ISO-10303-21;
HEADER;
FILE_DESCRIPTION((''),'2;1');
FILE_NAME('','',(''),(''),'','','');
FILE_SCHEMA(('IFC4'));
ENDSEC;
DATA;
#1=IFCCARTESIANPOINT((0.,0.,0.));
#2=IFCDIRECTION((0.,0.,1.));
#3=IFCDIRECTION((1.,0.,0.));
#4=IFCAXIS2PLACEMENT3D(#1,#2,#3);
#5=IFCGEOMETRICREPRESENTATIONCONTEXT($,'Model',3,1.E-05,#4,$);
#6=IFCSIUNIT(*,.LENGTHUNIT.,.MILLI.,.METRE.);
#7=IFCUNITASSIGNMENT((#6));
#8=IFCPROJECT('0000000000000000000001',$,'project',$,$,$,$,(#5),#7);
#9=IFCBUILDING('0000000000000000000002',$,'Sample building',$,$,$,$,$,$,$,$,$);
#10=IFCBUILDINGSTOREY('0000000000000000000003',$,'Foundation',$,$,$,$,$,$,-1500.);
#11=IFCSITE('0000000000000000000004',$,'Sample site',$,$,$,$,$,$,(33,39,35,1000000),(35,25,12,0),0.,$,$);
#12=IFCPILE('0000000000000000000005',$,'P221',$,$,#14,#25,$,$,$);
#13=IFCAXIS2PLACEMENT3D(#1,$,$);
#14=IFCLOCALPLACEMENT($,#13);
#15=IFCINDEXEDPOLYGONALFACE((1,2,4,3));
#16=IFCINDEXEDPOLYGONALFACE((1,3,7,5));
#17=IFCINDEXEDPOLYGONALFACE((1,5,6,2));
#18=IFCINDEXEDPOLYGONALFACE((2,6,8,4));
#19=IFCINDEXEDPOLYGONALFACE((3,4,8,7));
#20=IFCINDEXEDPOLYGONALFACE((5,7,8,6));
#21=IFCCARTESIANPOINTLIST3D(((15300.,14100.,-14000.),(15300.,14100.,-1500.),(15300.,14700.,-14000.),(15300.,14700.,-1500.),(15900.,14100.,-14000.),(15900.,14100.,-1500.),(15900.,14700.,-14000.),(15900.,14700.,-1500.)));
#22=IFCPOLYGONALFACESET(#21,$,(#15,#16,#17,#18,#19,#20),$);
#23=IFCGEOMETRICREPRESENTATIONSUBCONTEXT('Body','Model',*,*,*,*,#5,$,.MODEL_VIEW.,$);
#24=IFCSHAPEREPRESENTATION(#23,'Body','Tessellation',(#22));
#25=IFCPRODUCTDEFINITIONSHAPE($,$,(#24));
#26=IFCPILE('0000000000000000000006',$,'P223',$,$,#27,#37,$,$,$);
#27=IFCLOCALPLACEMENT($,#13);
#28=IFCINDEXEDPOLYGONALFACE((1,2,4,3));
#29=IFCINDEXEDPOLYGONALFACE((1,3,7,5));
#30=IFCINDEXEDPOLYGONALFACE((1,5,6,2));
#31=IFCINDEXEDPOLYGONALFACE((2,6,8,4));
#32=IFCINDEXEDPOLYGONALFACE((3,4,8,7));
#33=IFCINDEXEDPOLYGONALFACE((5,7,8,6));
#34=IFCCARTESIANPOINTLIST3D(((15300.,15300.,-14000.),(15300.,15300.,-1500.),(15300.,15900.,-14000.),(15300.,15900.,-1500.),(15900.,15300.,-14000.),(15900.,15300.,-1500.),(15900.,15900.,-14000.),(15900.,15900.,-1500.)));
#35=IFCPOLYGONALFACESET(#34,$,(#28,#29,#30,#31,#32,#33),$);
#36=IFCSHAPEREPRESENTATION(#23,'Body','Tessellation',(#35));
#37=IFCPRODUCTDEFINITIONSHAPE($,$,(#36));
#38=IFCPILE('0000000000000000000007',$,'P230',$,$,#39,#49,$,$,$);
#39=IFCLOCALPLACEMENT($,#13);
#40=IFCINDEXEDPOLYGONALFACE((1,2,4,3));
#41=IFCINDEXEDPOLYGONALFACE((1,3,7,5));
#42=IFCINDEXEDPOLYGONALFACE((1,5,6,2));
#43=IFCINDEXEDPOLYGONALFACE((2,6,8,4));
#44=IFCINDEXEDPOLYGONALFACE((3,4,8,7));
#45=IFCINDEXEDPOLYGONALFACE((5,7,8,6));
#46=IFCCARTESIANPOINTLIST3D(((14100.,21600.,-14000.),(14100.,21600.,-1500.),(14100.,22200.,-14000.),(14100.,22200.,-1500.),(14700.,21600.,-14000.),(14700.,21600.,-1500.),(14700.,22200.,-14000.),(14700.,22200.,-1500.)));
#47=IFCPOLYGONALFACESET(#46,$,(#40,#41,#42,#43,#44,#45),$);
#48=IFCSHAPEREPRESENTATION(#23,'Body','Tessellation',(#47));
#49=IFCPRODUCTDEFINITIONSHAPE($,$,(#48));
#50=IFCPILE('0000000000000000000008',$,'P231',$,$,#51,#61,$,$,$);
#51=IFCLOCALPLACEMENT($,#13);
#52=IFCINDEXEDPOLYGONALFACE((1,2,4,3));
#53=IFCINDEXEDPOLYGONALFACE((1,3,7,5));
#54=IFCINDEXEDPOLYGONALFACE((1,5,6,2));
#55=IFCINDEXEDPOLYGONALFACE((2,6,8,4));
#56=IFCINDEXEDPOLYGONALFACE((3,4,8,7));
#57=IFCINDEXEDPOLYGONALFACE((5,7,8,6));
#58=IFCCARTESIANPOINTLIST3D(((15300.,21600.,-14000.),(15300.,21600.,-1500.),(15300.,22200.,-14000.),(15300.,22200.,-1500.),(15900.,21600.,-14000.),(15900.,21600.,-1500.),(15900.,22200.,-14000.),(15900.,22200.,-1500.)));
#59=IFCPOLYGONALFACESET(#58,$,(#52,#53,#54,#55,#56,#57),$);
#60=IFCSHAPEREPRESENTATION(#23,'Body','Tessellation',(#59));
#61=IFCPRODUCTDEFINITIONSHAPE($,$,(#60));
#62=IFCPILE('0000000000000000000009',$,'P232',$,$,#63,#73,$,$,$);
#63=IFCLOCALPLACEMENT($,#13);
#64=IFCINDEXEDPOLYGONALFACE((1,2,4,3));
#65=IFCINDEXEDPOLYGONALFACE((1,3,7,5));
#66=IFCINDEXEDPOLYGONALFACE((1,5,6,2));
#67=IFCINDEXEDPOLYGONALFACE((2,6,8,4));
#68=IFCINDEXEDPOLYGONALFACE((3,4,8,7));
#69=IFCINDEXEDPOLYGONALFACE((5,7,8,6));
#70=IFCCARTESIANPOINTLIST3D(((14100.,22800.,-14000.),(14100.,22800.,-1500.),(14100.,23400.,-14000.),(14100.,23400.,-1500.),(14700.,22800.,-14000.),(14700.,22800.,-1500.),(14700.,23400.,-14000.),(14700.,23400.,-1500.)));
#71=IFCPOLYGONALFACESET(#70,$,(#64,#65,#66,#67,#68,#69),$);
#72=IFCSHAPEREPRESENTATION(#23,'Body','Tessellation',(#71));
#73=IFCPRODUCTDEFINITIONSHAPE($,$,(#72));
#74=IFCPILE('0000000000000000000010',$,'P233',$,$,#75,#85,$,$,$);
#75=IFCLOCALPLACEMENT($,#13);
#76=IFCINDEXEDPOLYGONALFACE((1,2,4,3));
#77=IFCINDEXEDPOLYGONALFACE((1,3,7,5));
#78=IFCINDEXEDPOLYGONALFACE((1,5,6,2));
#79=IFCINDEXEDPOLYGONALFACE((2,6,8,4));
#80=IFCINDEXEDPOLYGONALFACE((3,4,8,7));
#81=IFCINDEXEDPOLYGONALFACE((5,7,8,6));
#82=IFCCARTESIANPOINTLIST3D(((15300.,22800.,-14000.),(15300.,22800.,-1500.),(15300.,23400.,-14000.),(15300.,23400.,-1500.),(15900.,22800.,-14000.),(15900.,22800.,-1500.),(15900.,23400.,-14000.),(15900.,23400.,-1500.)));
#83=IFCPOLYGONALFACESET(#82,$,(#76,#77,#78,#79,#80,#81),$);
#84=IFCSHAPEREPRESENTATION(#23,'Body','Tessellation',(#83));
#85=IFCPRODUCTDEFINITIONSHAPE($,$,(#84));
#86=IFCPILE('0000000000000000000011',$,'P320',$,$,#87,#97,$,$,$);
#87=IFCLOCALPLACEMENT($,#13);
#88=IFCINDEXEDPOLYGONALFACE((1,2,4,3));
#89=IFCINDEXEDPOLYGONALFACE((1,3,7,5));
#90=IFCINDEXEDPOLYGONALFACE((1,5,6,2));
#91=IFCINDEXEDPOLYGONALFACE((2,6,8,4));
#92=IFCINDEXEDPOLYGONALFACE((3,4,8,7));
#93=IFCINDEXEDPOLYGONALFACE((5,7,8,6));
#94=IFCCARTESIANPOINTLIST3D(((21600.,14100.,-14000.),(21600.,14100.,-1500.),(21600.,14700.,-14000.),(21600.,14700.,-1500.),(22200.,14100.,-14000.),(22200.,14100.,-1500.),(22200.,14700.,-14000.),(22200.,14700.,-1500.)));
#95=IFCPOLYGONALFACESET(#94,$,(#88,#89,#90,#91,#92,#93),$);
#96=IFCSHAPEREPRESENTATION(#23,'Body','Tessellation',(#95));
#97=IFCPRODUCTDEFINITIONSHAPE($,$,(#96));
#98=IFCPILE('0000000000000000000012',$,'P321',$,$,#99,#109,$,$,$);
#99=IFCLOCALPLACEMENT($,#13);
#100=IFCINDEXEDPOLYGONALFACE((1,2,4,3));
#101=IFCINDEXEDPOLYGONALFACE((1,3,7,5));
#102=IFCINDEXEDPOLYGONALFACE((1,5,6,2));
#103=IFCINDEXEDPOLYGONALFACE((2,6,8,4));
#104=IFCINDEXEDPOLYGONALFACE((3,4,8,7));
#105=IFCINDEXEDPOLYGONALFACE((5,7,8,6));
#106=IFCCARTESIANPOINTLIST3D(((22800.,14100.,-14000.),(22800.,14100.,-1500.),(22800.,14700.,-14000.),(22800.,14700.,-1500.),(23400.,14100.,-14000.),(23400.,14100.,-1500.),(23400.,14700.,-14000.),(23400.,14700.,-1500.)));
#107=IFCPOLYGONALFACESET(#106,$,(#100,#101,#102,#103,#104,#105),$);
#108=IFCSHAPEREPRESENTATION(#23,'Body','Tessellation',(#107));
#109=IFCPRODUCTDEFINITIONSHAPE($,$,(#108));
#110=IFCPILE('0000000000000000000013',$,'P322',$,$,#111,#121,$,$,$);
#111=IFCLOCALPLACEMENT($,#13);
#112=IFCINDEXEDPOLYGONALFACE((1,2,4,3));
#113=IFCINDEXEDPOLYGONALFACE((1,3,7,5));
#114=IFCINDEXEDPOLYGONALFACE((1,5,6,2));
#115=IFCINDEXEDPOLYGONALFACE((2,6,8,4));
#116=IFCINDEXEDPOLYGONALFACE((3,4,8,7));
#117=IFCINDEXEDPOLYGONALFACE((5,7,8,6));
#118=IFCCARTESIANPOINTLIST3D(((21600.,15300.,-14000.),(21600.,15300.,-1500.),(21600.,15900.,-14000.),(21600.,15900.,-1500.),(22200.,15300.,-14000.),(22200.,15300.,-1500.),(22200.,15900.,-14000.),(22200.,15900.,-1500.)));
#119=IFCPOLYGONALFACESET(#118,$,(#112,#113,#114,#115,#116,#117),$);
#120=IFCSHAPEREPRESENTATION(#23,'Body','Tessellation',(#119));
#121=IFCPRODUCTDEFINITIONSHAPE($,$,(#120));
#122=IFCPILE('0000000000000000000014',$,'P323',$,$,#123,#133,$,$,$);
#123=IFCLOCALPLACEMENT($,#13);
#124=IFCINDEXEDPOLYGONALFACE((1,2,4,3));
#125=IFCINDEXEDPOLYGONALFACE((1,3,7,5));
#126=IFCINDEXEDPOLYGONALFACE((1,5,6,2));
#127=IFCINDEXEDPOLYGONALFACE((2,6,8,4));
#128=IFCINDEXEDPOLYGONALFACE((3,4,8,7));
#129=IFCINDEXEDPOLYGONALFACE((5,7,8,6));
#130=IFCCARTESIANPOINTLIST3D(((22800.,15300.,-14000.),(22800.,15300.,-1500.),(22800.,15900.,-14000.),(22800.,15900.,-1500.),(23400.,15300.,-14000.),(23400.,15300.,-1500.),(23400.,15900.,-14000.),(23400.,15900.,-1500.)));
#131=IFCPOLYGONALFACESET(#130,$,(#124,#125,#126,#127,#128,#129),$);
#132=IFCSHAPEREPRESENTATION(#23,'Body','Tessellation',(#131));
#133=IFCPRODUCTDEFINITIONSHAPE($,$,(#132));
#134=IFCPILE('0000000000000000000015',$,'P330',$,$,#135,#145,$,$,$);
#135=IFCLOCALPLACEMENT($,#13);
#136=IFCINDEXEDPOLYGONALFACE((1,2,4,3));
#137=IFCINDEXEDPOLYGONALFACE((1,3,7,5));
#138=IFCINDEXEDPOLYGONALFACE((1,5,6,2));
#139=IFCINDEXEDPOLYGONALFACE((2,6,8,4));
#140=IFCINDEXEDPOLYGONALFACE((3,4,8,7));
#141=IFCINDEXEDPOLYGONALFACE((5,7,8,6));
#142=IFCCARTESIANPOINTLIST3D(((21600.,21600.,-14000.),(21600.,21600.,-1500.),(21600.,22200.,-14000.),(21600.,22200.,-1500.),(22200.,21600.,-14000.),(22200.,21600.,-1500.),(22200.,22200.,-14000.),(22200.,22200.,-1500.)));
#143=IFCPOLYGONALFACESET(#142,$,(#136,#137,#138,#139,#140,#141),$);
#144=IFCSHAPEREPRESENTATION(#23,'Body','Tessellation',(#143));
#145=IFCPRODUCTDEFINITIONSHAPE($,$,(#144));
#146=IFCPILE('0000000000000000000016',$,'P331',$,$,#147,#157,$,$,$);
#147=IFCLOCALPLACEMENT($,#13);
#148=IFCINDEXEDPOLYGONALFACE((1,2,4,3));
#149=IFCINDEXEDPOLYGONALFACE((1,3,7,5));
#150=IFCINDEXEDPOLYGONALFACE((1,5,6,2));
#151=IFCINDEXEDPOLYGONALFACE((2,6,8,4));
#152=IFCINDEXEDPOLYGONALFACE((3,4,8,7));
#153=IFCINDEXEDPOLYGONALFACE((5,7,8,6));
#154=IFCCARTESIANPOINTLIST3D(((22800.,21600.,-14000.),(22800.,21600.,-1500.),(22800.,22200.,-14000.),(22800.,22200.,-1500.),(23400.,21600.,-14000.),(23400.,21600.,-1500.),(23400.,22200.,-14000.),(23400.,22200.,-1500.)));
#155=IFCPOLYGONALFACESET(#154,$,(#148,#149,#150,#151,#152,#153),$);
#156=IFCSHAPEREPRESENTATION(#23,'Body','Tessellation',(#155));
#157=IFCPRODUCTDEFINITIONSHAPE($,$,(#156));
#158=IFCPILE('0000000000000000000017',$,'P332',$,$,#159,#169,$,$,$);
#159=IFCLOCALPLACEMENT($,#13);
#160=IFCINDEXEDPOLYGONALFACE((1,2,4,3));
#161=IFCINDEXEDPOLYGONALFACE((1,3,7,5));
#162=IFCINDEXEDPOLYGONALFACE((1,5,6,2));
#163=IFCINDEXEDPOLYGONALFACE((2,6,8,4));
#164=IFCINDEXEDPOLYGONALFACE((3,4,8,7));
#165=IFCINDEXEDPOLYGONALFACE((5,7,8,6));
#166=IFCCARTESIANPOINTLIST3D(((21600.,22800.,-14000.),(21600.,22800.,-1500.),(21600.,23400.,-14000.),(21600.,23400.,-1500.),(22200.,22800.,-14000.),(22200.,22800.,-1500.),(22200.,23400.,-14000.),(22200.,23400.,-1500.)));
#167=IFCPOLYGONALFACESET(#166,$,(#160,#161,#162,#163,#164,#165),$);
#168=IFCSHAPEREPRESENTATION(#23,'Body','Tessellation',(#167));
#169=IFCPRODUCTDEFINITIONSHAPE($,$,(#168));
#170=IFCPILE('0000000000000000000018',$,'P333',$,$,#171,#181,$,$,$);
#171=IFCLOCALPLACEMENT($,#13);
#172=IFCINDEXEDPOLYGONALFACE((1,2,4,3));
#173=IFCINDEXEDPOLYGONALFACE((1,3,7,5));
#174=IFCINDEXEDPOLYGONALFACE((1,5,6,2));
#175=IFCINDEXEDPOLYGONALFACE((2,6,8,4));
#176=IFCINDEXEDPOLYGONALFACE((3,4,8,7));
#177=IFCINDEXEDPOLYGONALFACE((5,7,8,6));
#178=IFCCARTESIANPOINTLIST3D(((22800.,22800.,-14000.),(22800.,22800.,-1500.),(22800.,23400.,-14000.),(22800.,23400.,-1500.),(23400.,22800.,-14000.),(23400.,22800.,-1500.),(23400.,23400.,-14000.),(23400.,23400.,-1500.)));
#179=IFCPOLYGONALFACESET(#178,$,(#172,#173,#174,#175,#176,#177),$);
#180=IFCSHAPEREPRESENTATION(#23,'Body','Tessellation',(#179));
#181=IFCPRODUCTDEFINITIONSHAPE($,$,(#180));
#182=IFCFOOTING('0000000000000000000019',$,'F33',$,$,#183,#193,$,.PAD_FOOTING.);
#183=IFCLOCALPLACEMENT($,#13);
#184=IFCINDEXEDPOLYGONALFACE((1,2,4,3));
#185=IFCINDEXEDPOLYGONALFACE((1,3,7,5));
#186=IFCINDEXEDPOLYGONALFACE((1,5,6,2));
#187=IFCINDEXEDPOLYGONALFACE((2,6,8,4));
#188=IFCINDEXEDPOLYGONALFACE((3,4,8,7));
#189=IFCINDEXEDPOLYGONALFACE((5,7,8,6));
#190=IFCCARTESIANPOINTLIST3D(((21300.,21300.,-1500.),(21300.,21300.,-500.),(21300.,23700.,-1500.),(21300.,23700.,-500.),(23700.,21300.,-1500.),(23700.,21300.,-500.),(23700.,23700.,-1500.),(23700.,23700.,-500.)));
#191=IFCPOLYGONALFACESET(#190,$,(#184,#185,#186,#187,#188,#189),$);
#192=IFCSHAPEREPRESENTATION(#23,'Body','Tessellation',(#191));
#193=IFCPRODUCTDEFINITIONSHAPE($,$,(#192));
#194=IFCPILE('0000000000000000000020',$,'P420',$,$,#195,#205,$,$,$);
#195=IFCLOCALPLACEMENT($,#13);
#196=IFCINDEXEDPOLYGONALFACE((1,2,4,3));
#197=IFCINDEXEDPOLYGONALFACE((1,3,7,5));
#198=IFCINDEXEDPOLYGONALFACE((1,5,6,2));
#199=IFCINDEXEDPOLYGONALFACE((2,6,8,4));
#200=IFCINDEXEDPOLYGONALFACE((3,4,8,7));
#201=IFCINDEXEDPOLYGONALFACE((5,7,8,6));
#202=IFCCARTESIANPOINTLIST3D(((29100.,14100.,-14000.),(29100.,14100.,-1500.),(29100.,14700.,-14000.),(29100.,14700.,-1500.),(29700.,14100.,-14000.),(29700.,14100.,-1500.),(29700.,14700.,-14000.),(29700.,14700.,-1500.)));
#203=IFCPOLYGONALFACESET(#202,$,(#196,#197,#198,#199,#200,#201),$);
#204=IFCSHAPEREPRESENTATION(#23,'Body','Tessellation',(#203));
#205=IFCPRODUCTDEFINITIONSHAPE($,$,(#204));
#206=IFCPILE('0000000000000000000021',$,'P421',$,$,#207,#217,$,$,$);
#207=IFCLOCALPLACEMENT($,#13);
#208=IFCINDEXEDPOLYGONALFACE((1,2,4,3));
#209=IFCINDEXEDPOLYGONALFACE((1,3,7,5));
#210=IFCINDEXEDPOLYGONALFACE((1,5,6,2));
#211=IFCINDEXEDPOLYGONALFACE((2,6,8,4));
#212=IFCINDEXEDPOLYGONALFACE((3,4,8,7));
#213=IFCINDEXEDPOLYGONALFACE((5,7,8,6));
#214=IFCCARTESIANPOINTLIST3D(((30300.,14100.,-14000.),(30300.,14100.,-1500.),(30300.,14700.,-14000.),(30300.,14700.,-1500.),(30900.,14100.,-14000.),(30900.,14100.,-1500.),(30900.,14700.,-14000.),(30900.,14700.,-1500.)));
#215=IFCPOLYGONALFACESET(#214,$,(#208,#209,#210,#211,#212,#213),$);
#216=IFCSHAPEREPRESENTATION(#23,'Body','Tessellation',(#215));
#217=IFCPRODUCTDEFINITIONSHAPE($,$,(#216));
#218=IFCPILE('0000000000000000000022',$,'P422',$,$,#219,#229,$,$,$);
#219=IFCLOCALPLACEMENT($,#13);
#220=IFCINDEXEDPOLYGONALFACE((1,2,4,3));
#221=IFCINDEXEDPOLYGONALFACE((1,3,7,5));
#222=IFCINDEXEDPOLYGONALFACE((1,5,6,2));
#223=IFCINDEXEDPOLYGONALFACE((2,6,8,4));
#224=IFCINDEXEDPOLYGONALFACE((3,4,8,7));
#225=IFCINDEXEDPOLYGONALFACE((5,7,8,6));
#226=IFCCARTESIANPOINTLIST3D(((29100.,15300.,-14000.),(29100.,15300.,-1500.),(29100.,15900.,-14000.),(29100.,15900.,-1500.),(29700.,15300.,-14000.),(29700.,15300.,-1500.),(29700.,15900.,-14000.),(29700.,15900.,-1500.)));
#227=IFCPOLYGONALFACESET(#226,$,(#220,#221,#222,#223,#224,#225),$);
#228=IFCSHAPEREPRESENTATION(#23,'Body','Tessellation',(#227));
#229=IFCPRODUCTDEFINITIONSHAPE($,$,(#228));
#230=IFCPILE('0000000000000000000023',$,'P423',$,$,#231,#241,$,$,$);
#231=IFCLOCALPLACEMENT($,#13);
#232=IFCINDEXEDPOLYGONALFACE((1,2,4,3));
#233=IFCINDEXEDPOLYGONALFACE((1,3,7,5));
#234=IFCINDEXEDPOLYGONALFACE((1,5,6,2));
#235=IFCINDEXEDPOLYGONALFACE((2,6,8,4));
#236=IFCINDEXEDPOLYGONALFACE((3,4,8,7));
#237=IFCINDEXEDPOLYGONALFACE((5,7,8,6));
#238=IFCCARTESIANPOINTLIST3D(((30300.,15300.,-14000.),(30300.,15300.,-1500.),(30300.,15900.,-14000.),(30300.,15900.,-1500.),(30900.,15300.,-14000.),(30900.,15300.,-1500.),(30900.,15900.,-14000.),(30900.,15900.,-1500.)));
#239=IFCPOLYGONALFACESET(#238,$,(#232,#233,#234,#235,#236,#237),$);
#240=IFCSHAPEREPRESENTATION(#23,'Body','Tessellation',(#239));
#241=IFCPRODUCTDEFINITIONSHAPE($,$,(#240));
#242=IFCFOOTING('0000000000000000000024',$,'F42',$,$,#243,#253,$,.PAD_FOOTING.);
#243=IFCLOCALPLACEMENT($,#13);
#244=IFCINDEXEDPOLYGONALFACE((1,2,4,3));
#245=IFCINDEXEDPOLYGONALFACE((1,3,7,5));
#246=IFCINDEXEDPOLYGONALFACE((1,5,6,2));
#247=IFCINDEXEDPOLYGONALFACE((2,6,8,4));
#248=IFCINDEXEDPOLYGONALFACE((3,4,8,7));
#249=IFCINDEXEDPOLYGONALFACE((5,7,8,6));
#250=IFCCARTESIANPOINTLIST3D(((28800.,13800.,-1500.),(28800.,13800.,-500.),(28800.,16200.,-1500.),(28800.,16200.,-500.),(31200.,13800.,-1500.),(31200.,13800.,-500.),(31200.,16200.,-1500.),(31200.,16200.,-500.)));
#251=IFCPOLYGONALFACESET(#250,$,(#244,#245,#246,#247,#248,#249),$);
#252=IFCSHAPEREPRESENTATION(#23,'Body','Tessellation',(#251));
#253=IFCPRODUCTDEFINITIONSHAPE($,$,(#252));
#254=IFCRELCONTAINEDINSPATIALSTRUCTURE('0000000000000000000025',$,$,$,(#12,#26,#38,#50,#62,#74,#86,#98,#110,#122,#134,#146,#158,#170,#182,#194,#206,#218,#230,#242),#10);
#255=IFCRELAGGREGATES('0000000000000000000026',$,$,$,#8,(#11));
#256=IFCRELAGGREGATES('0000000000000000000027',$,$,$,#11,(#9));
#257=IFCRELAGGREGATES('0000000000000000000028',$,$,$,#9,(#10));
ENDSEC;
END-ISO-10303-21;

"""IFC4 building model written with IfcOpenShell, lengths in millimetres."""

from ifc_helpers import new_model, si_unit, frame, origin_with_axes, place, context, subcontext, project, spatial, indexed_curve, outline, extrude, element, save


model = new_model("IFC4")

# Units and contexts
model_context = context("Model", 3, precision=1e-05, world=origin_with_axes())
body_context = subcontext(model_context, "Body", "Model", "MODEL_VIEW")
ifc_project = project(units=[si_unit("LENGTHUNIT", "METRE", prefix="MILLI")], contexts=[model_context])

# Site, building, storey
site = spatial("IfcSite", under=ifc_project, Name="Sample site", RefLatitude=(33, 39, 35, 1000000), RefLongitude=(35, 25, 12, 0), RefElevation=0.0)
building = spatial("IfcBuilding", under=site, Name="Sample building")
storey = spatial("IfcBuildingStorey", under=building, Name="Foundation", Elevation=-1500.0)

# Piles
for number, where, z_axis, x_axis, name in (
    (1, (15300.0, 14100.0, -14000.0), (0.0, 0.0, 1.0), (1.0, 0.0, 0.0), "P221"),
    (2, (15300.0, 15300.0, -14000.0), (0.0, 0.0, 1.0), (1.0, 0.0, 0.0), "P223"),
    (3, (14100.0, 21600.0, -14000.0), (0.0, 0.0, 1.0), (1.0, 0.0, 0.0), "P230"),
    (4, (15300.0, 21600.0, -14000.0), (0.0, 0.0, 1.0), (1.0, 0.0, 0.0), "P231"),
    (5, (14100.0, 22800.0, -14000.0), (0.0, 0.0, 1.0), (1.0, 0.0, 0.0), "P232"),
    (6, (15300.0, 22800.0, -14000.0), (0.0, 0.0, 1.0), (1.0, 0.0, 0.0), "P233"),
    (7, (21600.0, 14100.0, -14000.0), (0.0, 0.0, 1.0), (1.0, 0.0, 0.0), "P320"),
    (8, (22800.0, 14100.0, -14000.0), (0.0, 0.0, 1.0), (1.0, 0.0, 0.0), "P321"),
    (9, (21600.0, 15300.0, -14000.0), (0.0, 0.0, 1.0), (1.0, 0.0, 0.0), "P322"),
    (10, (22800.0, 15300.0, -14000.0), (0.0, 0.0, 1.0), (1.0, 0.0, 0.0), "P323"),
    (11, (21600.0, 21600.0, -14000.0), (0.0, 0.0, 1.0), (1.0, 0.0, 0.0), "P330"),
    (12, (22800.0, 21600.0, -14000.0), (0.0, 0.0, 1.0), (1.0, 0.0, 0.0), "P331"),
    (13, (21600.0, 22800.0, -14000.0), (0.0, 0.0, 1.0), (1.0, 0.0, 0.0), "P332"),
    (14, (22800.0, 22800.0, -14000.0), (0.0, 0.0, 1.0), (1.0, 0.0, 0.0), "P333"),
):
    element("IfcPile", number, at=place(None, frame(where, z_axis=z_axis, x_axis=x_axis)), inside=storey, Name=name, context=body_context, shape_type="SweptSolid", body=[
        extrude(outline(indexed_curve([(0.0, 0.0), (0.0, 600.0), (600.0, 600.0), (600.0, 0.0), (0.0, 0.0)], self_intersect=False)), origin_with_axes(), (0.0, 0.0, 1.0), 12500.0),
    ])

# Footing
footing_1_placement = place(None, frame((21300.0, 21300.0, -1500.0), z_axis=(0.0, 0.0, 1.0), x_axis=(1.0, 0.0, 0.0)))
element("IfcFooting", 15, at=footing_1_placement, inside=storey, Name="F33", PredefinedType="PAD_FOOTING", context=body_context, shape_type="SweptSolid", body=[
    extrude(outline(indexed_curve([(0.0, 0.0), (0.0, 2400.0), (2400.0, 2400.0), (2400.0, 0.0), (0.0, 0.0)], self_intersect=False)), origin_with_axes(), (0.0, 0.0, 1.0), 1000.0),
])

# Piles
for number, where, z_axis, x_axis, name in (
    (16, (29100.0, 14100.0, -14000.0), (0.0, 0.0, 1.0), (1.0, 0.0, 0.0), "P420"),
    (17, (30300.0, 14100.0, -14000.0), (0.0, 0.0, 1.0), (1.0, 0.0, 0.0), "P421"),
    (18, (29100.0, 15300.0, -14000.0), (0.0, 0.0, 1.0), (1.0, 0.0, 0.0), "P422"),
    (19, (30300.0, 15300.0, -14000.0), (0.0, 0.0, 1.0), (1.0, 0.0, 0.0), "P423"),
):
    element("IfcPile", number, at=place(None, frame(where, z_axis=z_axis, x_axis=x_axis)), inside=storey, Name=name, context=body_context, shape_type="SweptSolid", body=[
        extrude(outline(indexed_curve([(0.0, 0.0), (0.0, 600.0), (600.0, 600.0), (600.0, 0.0), (0.0, 0.0)], self_intersect=False)), origin_with_axes(), (0.0, 0.0, 1.0), 12500.0),
    ])

# Footing
footing_2_placement = place(None, frame((28800.0, 13800.0, -1500.0), z_axis=(0.0, 0.0, 1.0), x_axis=(1.0, 0.0, 0.0)))
element("IfcFooting", 20, at=footing_2_placement, inside=storey, Name="F42", PredefinedType="PAD_FOOTING", context=body_context, shape_type="SweptSolid", body=[
    extrude(outline(indexed_curve([(0.0, 0.0), (0.0, 2400.0), (2400.0, 2400.0), (2400.0, 0.0), (0.0, 0.0)], self_intersect=False)), origin_with_axes(), (0.0, 0.0, 1.0), 1000.0),
])

save(model, "model.ifc")
